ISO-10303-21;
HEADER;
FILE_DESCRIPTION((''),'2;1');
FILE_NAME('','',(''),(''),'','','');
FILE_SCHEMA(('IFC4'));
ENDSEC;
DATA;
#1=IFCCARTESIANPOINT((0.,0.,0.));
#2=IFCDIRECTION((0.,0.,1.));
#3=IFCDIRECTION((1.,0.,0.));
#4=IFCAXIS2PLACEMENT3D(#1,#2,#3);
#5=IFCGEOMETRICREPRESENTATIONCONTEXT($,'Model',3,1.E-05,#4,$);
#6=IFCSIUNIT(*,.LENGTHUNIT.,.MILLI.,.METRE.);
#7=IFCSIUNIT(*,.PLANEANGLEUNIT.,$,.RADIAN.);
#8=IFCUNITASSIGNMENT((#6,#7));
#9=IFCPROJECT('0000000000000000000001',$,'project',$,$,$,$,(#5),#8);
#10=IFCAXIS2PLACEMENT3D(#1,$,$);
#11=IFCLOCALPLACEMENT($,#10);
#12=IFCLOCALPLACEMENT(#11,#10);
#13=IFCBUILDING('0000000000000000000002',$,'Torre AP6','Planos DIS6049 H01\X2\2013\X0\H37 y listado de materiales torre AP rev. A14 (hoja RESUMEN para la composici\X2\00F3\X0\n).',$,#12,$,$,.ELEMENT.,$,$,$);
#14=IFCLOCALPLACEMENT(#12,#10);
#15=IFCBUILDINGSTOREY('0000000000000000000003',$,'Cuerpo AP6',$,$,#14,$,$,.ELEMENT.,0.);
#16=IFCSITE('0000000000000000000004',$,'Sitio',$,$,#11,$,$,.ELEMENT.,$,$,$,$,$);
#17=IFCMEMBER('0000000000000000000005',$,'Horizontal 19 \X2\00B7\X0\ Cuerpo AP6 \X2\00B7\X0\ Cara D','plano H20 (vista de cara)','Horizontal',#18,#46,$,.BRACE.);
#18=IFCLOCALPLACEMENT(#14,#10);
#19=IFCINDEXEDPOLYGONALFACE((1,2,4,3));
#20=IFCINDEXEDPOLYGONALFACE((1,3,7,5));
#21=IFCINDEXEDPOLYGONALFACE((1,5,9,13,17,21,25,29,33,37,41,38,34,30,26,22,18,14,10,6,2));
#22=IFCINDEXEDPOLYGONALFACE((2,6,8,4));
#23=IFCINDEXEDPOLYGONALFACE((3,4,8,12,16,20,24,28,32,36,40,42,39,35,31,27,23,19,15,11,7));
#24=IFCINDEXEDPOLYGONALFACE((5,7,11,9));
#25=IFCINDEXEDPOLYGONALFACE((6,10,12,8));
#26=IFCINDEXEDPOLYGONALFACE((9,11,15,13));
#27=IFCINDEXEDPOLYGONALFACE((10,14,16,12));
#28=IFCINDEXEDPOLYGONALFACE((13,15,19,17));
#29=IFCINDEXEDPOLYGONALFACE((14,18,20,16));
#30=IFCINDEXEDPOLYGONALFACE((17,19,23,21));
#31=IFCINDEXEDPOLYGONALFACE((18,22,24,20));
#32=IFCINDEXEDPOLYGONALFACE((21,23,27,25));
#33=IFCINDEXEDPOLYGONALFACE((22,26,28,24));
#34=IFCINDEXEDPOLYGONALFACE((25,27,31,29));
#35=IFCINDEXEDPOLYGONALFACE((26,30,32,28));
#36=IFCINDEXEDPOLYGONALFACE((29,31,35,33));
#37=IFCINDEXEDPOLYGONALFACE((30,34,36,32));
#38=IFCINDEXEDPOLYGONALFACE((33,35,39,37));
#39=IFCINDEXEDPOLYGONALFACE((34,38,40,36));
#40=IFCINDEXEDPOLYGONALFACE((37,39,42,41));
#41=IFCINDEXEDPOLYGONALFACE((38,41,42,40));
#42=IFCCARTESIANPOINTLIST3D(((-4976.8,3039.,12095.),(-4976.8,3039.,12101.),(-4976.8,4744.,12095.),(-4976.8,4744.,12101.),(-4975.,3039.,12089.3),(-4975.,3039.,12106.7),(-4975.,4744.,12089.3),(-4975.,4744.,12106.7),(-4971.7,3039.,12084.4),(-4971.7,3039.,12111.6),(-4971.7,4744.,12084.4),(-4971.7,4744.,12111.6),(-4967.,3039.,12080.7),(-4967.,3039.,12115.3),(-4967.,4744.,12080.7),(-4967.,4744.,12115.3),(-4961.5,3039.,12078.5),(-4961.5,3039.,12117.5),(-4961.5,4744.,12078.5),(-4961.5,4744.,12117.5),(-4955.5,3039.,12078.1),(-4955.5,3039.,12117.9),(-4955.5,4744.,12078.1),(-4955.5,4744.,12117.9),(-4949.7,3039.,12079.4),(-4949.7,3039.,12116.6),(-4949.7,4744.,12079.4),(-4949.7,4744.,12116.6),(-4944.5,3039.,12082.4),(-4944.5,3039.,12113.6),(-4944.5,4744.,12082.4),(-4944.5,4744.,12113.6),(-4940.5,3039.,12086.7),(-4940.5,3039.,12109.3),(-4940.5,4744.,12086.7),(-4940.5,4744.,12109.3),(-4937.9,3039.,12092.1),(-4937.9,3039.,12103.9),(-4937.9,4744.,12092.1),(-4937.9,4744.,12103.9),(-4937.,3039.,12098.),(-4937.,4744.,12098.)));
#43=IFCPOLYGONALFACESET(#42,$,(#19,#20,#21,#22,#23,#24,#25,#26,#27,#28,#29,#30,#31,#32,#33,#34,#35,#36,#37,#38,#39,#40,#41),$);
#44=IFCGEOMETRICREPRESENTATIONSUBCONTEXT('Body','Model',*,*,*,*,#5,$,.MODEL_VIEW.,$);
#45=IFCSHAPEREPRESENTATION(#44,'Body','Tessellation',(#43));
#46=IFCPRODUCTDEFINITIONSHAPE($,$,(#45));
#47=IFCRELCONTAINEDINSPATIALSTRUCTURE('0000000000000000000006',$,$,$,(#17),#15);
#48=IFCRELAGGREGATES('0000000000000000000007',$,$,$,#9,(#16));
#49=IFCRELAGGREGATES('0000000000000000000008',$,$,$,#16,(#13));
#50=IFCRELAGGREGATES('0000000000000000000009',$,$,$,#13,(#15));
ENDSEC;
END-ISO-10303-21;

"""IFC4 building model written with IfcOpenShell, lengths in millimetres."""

from ifc_helpers import new_model, si_unit, frame, origin, origin_with_axes, place, context, subcontext, project, spatial, circle, extrude, element, save


model = new_model("IFC4")

# Units and contexts
model_context = context("Model", 3, precision=1e-05, world=origin_with_axes())
body_context = subcontext(model_context, "Body", "Model", "MODEL_VIEW")
ifc_project = project(units=[si_unit("LENGTHUNIT", "METRE", prefix="MILLI"), si_unit("PLANEANGLEUNIT", "RADIAN")], contexts=[model_context])

# Site, building, storey
site_placement = place(None, origin())
site = spatial("IfcSite", under=ifc_project, at=site_placement, Name="Sitio", CompositionType="ELEMENT")
building_placement = place(site_placement, origin())
building = spatial("IfcBuilding", under=site, at=building_placement, Name="Torre AP6", Description="Planos DIS6049 H01–H37 y listado de materiales torre AP rev. A14 (hoja RESUMEN para la composición).", CompositionType="ELEMENT")
storey_placement = place(building_placement, origin())
storey = spatial("IfcBuildingStorey", under=building, at=storey_placement, Name="Cuerpo AP6", CompositionType="ELEMENT", Elevation=0.0)

# Member
for number, where, z_axis, x_axis, name in (
    (1, (-4957.0, 3039.0, 12098.0), (0.0, 1.0, 0.0), (1.0, 0.0, 0.0), "Horizontal 19 · Cuerpo AP6 · Cara D"),
):
    element("IfcMember", number, at=place(storey_placement, frame(where, z_axis=z_axis, x_axis=x_axis)), inside=storey, Name=name, Description="plano H20 (vista de cara)", ObjectType="Horizontal", PredefinedType="BRACE", context=body_context, shape_type="SweptSolid", body=[
        extrude(circle(Radius=20.0), None, (0.0, 0.0, 1.0), 1705.0),
    ])

save(model, "model.ifc")
